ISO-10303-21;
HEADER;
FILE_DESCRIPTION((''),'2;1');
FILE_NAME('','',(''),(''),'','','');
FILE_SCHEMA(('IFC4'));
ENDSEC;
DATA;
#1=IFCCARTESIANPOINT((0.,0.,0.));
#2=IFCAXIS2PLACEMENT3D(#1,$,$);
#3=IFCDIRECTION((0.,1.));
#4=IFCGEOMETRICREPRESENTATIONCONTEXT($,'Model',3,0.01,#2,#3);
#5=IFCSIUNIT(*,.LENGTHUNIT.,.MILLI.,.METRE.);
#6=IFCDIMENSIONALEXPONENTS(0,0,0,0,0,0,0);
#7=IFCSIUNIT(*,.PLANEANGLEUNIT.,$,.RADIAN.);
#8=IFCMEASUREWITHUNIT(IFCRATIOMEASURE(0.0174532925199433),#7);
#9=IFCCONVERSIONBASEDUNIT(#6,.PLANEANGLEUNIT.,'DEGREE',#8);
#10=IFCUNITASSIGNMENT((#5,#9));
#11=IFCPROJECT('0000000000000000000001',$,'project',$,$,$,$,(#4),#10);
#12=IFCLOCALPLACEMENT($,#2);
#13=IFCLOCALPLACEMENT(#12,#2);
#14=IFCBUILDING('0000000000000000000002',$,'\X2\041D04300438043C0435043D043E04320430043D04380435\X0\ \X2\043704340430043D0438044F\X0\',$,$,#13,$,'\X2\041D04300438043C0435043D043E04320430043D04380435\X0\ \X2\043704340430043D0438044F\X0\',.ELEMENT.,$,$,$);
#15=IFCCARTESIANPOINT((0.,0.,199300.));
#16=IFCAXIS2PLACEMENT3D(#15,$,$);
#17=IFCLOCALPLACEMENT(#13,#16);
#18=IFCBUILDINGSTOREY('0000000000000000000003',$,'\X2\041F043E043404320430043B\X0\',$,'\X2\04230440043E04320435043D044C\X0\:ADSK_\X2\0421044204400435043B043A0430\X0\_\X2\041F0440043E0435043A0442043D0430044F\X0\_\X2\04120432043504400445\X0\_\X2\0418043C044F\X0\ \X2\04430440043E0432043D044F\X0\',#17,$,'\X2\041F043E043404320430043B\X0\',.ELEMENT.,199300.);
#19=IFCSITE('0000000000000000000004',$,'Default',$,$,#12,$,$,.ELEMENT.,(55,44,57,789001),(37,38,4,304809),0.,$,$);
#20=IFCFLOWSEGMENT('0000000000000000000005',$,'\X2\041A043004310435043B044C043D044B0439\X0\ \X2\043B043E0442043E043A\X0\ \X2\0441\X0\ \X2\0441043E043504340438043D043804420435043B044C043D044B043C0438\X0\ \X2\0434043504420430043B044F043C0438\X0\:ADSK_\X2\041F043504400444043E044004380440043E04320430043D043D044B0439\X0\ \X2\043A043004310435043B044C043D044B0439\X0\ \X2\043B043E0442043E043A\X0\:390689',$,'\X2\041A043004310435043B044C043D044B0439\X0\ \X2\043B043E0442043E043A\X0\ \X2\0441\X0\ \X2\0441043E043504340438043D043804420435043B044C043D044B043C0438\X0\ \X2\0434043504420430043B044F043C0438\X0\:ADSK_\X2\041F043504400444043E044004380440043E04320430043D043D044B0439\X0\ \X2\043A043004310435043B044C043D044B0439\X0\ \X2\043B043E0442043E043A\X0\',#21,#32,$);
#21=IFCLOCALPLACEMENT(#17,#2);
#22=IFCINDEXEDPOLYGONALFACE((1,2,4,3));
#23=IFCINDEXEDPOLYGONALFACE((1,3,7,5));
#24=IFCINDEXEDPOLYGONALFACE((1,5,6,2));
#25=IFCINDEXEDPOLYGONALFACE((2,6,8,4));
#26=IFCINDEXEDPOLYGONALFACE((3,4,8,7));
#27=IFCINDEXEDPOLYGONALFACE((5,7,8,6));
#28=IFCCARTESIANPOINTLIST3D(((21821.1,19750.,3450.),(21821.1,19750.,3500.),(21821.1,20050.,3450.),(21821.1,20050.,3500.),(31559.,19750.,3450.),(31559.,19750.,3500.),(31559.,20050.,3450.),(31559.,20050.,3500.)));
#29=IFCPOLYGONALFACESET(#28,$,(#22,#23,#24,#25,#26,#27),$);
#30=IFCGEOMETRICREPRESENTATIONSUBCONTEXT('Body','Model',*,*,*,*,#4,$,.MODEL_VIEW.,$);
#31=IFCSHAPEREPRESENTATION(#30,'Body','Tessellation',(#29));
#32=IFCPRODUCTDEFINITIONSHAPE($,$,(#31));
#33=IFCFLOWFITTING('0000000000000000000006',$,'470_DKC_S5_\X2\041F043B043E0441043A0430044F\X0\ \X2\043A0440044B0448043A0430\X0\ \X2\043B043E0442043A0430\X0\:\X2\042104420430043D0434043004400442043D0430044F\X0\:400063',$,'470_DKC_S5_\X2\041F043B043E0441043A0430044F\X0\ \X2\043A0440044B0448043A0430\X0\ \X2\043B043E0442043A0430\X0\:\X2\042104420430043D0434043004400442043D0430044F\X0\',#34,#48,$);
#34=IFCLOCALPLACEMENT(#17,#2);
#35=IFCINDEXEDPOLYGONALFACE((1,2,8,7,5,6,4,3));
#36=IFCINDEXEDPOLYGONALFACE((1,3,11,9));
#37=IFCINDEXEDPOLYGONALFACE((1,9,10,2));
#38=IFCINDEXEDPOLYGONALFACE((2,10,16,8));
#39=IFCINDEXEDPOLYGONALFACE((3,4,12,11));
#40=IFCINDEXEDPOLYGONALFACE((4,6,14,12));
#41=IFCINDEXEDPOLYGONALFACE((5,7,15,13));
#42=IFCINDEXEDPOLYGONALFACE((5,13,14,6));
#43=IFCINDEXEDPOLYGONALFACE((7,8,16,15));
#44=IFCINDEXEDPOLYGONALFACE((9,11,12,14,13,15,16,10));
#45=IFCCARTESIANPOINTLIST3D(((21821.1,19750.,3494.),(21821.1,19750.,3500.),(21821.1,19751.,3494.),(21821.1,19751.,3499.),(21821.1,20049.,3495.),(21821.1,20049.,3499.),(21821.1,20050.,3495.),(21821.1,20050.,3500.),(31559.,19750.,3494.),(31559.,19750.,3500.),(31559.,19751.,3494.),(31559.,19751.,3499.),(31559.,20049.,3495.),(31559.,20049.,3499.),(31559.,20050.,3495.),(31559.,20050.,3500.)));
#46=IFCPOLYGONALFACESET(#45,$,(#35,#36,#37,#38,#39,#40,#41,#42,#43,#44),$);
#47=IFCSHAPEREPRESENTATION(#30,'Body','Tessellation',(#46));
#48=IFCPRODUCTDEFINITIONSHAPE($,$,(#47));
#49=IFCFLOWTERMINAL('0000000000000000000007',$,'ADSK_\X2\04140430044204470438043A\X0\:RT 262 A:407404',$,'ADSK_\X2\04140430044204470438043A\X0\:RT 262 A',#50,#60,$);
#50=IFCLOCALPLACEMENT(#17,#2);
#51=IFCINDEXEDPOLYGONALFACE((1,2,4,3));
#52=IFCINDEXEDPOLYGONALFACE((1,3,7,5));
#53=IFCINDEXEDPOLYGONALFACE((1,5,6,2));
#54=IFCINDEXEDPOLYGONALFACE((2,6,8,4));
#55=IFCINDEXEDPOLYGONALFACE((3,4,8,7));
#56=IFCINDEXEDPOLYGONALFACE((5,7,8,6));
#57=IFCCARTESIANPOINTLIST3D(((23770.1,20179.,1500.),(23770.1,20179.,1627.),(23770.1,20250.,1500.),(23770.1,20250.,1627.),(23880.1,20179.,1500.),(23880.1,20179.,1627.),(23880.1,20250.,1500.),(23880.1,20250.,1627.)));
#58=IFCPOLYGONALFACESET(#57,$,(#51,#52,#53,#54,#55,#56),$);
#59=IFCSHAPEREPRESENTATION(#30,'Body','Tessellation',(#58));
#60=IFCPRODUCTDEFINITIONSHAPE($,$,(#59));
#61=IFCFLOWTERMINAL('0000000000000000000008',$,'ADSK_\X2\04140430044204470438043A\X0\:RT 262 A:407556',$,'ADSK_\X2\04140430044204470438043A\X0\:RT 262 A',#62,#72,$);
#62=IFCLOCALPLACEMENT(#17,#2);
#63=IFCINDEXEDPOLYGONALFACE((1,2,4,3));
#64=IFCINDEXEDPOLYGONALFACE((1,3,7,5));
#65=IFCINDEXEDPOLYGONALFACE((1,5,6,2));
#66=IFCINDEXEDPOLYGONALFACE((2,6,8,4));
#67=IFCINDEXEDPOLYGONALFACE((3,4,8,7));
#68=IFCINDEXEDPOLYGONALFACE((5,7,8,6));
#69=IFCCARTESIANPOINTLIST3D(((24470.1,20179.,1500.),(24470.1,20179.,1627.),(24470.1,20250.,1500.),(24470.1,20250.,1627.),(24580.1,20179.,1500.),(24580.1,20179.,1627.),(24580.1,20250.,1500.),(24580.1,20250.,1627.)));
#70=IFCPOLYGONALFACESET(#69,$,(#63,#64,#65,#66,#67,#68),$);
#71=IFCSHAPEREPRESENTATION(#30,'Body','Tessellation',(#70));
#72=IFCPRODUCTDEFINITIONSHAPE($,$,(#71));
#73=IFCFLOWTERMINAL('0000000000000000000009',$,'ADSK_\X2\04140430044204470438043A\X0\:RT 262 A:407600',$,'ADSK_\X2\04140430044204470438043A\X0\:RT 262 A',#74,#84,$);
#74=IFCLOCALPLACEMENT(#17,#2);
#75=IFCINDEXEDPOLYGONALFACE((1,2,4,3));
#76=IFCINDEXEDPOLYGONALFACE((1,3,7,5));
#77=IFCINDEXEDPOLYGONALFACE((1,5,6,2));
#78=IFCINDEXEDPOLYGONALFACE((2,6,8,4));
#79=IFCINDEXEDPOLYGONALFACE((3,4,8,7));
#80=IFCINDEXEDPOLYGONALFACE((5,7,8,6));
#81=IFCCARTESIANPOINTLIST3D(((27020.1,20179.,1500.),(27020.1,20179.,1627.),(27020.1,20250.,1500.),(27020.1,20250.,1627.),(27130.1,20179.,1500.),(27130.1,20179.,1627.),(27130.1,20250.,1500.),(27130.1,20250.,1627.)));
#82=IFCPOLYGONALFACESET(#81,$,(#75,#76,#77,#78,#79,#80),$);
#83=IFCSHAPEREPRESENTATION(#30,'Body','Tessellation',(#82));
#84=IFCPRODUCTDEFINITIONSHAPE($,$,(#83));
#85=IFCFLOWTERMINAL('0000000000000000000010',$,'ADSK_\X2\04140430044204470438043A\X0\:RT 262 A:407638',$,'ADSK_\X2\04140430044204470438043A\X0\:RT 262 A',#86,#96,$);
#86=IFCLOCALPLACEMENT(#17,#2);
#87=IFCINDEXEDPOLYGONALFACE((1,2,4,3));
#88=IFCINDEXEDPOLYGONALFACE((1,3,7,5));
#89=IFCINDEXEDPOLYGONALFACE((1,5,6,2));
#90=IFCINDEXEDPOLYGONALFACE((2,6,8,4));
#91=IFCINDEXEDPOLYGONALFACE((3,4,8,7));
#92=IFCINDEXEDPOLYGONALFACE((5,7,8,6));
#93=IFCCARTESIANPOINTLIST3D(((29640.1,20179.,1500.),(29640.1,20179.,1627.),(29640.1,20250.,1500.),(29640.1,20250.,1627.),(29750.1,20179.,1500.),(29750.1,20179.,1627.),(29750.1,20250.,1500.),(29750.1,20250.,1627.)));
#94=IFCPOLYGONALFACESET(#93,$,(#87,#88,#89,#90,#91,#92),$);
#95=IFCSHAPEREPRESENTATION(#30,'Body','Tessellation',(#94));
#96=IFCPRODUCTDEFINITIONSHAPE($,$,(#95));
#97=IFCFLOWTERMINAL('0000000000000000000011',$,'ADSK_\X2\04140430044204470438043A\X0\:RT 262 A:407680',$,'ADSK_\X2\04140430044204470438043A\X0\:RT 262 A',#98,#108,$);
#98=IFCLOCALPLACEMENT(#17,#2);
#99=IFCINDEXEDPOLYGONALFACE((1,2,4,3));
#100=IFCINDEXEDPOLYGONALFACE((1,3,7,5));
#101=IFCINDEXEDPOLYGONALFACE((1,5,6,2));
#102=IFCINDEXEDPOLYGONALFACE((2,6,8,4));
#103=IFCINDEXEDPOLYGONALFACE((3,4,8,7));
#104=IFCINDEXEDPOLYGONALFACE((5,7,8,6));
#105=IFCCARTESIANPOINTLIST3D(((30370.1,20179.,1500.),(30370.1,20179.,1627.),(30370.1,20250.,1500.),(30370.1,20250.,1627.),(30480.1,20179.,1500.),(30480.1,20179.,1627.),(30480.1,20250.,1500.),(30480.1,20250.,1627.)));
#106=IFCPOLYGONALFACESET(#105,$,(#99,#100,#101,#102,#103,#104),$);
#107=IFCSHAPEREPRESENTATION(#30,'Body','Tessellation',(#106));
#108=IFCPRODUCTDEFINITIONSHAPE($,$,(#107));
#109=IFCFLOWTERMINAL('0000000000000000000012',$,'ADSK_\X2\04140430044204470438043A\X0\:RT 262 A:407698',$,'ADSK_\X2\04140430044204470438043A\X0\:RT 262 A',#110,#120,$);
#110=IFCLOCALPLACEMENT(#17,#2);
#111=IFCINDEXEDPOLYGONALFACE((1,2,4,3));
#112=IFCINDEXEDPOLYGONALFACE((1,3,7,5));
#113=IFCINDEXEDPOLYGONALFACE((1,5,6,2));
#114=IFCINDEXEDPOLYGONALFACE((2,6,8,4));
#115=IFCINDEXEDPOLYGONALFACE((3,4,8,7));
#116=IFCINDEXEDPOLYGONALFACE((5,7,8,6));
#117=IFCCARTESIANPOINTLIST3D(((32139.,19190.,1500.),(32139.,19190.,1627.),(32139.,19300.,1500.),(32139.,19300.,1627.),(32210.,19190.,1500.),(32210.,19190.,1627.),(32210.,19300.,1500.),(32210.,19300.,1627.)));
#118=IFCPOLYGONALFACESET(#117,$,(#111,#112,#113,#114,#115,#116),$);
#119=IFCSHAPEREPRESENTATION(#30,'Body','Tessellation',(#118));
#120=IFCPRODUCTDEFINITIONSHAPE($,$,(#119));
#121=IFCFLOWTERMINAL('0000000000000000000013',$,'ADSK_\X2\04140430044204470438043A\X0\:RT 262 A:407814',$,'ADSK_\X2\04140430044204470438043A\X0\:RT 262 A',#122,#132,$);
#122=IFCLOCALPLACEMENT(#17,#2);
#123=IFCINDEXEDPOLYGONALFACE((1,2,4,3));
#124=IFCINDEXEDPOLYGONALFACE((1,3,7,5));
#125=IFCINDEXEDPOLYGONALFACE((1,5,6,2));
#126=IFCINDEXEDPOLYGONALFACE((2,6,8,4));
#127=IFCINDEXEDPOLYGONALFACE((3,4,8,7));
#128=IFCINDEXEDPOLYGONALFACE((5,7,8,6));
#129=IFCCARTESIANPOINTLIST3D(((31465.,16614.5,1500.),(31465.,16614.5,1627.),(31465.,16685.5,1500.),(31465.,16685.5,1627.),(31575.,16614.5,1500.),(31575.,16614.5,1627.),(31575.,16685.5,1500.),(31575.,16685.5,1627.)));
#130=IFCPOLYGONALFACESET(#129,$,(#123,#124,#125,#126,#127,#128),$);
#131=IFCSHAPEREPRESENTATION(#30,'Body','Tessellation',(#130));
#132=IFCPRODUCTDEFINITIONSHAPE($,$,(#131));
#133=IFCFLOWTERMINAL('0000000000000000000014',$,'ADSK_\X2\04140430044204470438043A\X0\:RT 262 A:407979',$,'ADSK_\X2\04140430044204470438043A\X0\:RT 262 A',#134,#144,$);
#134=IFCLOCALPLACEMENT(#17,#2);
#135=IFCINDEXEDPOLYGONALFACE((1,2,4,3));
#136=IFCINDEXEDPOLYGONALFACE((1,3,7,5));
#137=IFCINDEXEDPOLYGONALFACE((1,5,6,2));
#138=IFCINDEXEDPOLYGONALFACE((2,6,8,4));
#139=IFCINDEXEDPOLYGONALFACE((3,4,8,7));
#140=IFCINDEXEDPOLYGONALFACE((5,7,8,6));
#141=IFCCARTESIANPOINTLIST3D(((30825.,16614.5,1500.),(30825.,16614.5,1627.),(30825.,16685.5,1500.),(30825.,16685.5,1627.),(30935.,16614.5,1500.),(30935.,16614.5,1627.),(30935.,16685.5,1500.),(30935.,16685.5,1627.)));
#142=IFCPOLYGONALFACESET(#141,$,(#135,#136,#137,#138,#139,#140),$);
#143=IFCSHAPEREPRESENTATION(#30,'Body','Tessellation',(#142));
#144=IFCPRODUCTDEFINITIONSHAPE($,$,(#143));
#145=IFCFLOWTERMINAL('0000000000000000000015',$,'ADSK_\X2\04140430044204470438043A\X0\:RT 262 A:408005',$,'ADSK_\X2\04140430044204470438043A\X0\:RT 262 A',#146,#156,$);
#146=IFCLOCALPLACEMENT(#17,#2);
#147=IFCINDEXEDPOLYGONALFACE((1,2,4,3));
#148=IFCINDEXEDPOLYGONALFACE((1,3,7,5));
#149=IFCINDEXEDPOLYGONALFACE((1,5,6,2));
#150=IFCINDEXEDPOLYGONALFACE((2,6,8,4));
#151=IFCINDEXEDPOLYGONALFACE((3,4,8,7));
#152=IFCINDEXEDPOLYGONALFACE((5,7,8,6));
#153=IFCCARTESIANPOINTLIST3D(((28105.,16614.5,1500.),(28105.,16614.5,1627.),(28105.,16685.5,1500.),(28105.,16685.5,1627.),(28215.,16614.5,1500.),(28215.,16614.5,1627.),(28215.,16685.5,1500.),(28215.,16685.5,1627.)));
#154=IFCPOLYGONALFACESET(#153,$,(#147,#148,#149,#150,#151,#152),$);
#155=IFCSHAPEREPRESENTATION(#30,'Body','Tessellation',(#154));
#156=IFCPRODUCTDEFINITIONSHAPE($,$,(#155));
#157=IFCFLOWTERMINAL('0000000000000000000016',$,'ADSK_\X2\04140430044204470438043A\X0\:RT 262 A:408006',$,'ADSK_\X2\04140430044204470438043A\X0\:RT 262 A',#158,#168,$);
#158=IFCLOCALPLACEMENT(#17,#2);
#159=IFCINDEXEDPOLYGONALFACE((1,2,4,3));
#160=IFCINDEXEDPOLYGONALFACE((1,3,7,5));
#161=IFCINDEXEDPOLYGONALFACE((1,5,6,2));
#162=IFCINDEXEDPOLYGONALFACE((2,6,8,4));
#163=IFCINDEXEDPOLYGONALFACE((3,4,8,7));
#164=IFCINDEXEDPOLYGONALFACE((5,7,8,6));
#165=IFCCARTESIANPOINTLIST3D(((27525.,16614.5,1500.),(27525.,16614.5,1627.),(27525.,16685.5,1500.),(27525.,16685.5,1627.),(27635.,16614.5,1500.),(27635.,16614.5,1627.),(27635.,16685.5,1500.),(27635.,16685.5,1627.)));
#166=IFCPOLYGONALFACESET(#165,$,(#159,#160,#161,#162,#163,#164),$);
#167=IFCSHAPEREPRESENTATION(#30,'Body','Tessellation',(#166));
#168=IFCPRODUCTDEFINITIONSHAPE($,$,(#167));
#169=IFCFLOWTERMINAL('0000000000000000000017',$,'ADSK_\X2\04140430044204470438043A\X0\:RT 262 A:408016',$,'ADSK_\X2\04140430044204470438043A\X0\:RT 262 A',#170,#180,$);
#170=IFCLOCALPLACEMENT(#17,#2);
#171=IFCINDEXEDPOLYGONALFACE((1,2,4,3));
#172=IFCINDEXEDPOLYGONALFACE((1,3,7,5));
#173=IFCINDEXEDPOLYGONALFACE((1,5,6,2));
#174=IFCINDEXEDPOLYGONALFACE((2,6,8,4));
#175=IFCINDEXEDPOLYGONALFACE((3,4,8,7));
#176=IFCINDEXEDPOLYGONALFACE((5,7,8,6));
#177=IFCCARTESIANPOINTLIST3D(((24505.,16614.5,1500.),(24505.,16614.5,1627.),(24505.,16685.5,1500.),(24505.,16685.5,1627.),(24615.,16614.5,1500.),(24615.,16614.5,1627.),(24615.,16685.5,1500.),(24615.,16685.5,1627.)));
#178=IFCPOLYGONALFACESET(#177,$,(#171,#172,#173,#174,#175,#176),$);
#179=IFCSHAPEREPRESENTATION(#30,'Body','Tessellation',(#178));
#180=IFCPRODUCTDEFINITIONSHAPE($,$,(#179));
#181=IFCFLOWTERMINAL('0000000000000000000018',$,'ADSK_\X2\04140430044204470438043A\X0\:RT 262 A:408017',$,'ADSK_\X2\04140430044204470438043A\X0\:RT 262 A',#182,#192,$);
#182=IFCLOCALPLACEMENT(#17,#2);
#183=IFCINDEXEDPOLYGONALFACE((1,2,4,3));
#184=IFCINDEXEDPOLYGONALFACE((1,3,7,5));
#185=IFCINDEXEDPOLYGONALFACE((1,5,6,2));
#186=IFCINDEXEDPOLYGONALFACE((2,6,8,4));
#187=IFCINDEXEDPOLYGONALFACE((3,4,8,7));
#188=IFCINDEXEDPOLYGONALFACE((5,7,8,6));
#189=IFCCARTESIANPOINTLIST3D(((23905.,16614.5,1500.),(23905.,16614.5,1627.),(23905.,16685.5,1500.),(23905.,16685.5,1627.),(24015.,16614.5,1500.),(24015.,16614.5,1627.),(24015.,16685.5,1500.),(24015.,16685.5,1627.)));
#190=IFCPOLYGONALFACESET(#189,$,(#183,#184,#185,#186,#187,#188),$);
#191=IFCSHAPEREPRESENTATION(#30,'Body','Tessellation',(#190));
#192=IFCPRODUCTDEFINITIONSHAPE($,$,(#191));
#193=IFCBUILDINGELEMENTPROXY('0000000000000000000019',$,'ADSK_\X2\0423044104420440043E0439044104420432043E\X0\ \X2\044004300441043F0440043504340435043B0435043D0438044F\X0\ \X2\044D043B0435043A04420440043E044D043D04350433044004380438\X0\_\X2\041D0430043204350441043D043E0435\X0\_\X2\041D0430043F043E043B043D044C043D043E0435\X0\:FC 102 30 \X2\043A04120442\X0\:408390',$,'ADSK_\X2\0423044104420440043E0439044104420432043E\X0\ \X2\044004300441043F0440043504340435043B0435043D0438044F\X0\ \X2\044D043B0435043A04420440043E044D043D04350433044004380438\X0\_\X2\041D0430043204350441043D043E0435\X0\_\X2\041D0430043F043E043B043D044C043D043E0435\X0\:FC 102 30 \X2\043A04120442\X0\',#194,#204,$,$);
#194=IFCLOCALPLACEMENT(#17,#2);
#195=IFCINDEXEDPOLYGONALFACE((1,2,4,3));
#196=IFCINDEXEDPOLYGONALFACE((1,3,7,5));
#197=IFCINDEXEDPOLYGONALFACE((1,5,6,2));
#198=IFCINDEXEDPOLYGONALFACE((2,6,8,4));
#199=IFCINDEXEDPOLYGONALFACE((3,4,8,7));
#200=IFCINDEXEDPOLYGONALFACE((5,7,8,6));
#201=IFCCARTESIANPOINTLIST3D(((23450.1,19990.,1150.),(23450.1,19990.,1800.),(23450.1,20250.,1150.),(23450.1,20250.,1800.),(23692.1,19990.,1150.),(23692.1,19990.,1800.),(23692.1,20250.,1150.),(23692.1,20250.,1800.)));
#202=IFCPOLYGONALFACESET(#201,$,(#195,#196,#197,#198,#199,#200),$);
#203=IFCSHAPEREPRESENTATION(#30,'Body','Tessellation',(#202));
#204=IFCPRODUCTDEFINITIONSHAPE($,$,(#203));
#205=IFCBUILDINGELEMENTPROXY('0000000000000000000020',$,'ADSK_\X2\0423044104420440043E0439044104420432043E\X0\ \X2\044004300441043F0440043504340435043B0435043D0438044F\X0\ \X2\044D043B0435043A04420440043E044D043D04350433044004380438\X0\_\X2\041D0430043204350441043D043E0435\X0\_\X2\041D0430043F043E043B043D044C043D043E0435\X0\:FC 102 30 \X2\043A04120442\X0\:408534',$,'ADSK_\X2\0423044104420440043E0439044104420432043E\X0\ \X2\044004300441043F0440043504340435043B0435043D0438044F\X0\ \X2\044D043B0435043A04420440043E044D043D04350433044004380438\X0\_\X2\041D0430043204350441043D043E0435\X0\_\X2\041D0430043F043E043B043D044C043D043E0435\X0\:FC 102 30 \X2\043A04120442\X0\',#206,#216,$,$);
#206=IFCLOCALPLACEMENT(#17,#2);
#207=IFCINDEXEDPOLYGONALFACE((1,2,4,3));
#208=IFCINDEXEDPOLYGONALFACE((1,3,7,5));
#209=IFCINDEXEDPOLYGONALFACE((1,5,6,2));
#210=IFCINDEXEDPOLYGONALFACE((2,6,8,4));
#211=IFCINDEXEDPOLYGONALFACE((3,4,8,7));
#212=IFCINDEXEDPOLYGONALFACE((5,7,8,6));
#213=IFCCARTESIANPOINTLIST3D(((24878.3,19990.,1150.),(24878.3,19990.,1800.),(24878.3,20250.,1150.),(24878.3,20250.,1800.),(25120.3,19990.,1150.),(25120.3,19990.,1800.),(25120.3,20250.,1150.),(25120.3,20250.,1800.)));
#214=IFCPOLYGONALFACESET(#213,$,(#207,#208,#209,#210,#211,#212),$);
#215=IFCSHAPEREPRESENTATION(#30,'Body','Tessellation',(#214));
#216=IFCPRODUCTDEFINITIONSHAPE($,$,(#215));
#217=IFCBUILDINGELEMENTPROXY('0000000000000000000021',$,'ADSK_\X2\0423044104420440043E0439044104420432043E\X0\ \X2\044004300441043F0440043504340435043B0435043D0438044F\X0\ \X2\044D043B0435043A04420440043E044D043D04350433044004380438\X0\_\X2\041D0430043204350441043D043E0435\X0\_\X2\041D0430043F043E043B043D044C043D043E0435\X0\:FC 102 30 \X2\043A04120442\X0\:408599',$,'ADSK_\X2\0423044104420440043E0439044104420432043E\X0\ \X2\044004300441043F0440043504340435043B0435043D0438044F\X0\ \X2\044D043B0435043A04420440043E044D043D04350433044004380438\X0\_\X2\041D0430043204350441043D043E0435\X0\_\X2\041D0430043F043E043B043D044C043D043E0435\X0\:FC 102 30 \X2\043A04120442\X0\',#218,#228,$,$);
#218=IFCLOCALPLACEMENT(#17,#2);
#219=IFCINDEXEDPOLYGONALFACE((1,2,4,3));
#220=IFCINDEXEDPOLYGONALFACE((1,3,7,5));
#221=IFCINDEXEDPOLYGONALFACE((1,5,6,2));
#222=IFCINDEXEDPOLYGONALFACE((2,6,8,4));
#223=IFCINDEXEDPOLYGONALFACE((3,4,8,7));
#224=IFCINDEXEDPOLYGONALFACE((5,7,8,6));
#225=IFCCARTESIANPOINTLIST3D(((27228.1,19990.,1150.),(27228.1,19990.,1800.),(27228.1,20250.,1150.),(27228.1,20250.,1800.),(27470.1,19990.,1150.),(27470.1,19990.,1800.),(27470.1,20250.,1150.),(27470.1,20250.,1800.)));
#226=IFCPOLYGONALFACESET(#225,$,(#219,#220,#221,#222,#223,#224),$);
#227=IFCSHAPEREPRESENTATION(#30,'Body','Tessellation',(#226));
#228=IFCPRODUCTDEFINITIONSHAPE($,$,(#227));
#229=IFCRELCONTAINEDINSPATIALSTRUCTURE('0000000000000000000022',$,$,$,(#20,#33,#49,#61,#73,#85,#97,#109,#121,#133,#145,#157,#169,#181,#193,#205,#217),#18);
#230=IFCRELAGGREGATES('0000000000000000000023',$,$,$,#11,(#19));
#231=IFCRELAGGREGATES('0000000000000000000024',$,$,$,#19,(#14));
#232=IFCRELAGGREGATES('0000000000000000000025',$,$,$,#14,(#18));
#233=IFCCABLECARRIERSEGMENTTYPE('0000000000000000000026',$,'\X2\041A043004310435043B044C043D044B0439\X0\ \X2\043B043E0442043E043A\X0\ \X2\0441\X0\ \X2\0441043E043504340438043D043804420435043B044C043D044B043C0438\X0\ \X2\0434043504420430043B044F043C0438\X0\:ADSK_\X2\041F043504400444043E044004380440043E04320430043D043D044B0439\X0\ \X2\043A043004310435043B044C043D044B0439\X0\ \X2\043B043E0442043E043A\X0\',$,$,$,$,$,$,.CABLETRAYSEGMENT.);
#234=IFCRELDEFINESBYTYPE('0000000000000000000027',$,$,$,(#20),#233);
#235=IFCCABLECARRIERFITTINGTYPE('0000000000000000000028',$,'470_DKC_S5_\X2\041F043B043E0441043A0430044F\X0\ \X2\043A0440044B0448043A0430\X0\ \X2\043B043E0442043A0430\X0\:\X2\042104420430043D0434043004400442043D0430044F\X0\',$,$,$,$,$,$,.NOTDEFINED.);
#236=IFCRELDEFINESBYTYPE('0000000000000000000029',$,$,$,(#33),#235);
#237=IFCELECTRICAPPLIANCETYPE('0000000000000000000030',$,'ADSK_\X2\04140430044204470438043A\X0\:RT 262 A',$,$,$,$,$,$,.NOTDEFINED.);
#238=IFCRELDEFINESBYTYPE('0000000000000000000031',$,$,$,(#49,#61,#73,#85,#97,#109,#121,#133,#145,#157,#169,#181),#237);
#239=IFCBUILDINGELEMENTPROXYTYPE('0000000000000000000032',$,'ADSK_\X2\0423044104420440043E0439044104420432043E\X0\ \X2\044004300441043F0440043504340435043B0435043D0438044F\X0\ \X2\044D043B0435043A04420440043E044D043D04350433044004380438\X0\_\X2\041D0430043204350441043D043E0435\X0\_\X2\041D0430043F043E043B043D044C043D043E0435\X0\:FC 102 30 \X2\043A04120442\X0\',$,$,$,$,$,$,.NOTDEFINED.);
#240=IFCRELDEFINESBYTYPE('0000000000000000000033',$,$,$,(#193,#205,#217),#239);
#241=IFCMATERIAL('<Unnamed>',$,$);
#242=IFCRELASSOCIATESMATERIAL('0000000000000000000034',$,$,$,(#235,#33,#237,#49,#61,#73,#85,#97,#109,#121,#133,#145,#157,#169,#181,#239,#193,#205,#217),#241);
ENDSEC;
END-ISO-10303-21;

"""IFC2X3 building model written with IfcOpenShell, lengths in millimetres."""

from ifc_helpers import new_model, entity, si_unit, converted_unit, direction, frame, origin, origin_2d_with_axis, place, context, subcontext, project, spatial, polyline, rectangle, outline, extrude, source, transform, mapped, material, type_object, type_shapes, element, save


model = new_model("IFC2X3")

# Units and contexts
model_context = context("Model", 3, precision=0.01, world=origin(), true_north=direction((0.0, 1.0)))
body_context = subcontext(model_context, "Body", "Model", "MODEL_VIEW")
ifc_project = project(units=[si_unit("LENGTHUNIT", "METRE", prefix="MILLI"), converted_unit("PLANEANGLEUNIT", "DEGREE", entity("IfcRatioMeasure", 0.0174532925199433), si_unit("PLANEANGLEUNIT", "RADIAN"), dimensions=[0, 0, 0, 0, 0, 0, 0])], contexts=[model_context])

# Site, building, storey
site_placement = place(None, origin())
site = spatial("IfcSite", under=ifc_project, at=site_placement, Name="Default", CompositionType="ELEMENT", RefLatitude=(55, 44, 57, 789001), RefLongitude=(37, 38, 4, 304809), RefElevation=0.0)
building_placement = place(site_placement, origin())
building = spatial("IfcBuilding", under=site, at=building_placement, Name="Наименование здания", LongName="Наименование здания", CompositionType="ELEMENT")
storey_placement = place(building_placement, frame((0.0, 0.0, 199300.0)))
storey = spatial("IfcBuildingStorey", under=building, at=storey_placement, Name="Подвал", ObjectType="Уровень:ADSK_Стрелка_Проектная_Вверх_Имя уровня", LongName="Подвал", CompositionType="ELEMENT", Elevation=199300.0)

# Flow segment
cable_carrier_segment_type = type_object("IfcCableCarrierSegmentType", Name="Кабельный лоток с соединительными деталями:ADSK_Перфорированный кабельный лоток", PredefinedType="CABLETRAYSEGMENT")
flow_segment_placement = place(storey_placement, frame((21821.1, 19750.0, 3450.0)))
element("IfcFlowSegment", 1, at=flow_segment_placement, inside=storey, type_object=cable_carrier_segment_type, Name="Кабельный лоток с соединительными деталями:ADSK_Перфорированный кабельный лоток:390689", ObjectType="Кабельный лоток с соединительными деталями:ADSK_Перфорированный кабельный лоток", context=body_context, shape_type="SweptSolid", body=[
    extrude(rectangle(XDim=9737.9, YDim=300.0, at=origin_2d_with_axis()), frame((4868.9, 150.0, 0.0), z_axis=(0.0, 0.0, 1.0), x_axis=(-1.0, 0.0, 0.0)), (0.0, 0.0, 1.0), 50.0),
])

# Flow fitting
ifc_material = material(Name="<Unnamed>")
cable_carrier_fitting_type_1 = type_object("IfcCableCarrierFittingType", Name="470_DKC_S5_Плоская крышка лотка:Стандартная", PredefinedType="NOTDEFINED", material=ifc_material)
shared_shape_1 = source(origin(), body_context, "Body", "SweptSolid", [
    extrude(outline(polyline([(-150.0, -2.0), (-149.0, -2.0), (-149.0, 2.0), (149.0, 2.0), (149.0, -3.0), (150.0, -3.0), (150.0, 3.0), (-150.0, 3.0), (-150.0, -2.0)])), frame((0.0, 150.0, 3.0), z_axis=(1.0, 0.0, 0.0), x_axis=(0.0, 1.0, 0.0)), (0.0, 0.0, 1.0), 9737.9),
])
type_shapes(cable_carrier_fitting_type_1, [shared_shape_1])
flow_fitting_placement = place(storey_placement, frame((31559.0, 20050.0, 3494.0), z_axis=(0.0, 0.0, 1.0), x_axis=(-1.0, 0.0, 0.0)))
element("IfcFlowFitting", 2, at=flow_fitting_placement, inside=storey, type_object=cable_carrier_fitting_type_1, material=ifc_material, Name="470_DKC_S5_Плоская крышка лотка:Стандартная:400063", ObjectType="470_DKC_S5_Плоская крышка лотка:Стандартная", context=body_context, shape_type="MappedRepresentation", body=[
    mapped(shared_shape_1, transform((0.0, 0.0, 0.0), scale=1.0)),
])

# Flow terminals
electric_appliance_type = type_object("IfcElectricApplianceType", Name="ADSK_Датчик:RT 262 A", PredefinedType="NOTDEFINED", material=ifc_material)
shared_shape_2 = source(origin(), body_context, "Body", "SweptSolid", [
    extrude(rectangle(XDim=71.0, YDim=110.0, at=origin_2d_with_axis()), frame((0.0, 0.0, 0.0), z_axis=(0.0, 0.0, 1.0), x_axis=(-1.0, 0.0, 0.0)), (0.0, 0.0, 1.0), 127.0),
])
type_shapes(electric_appliance_type, [shared_shape_2])
for number, where, z_axis, x_axis, name in (
    (3, (23825.1, 20214.5, 1500.0), (0.0, 0.0, 1.0), (0.0, -1.0, 0.0), "ADSK_Датчик:RT 262 A:407404"),
    (4, (24525.1, 20214.5, 1500.0), (0.0, 0.0, 1.0), (0.0, -1.0, 0.0), "ADSK_Датчик:RT 262 A:407556"),
    (5, (27075.1, 20214.5, 1500.0), (0.0, 0.0, 1.0), (0.0, -1.0, 0.0), "ADSK_Датчик:RT 262 A:407600"),
    (6, (29695.1, 20214.5, 1500.0), (0.0, 0.0, 1.0), (0.0, -1.0, 0.0), "ADSK_Датчик:RT 262 A:407638"),
    (7, (30425.1, 20214.5, 1500.0), (0.0, 0.0, 1.0), (0.0, -1.0, 0.0), "ADSK_Датчик:RT 262 A:407680"),
    (8, (32174.5, 19245.0, 1500.0), (0.0, 0.0, 1.0), (-1.0, 0.0, 0.0), "ADSK_Датчик:RT 262 A:407698"),
    (9, (31520.0, 16650.0, 1500.0), (0.0, 0.0, 1.0), (0.0, 1.0, 0.0), "ADSK_Датчик:RT 262 A:407814"),
    (10, (30880.0, 16650.0, 1500.0), (0.0, 0.0, 1.0), (0.0, 1.0, 0.0), "ADSK_Датчик:RT 262 A:407979"),
    (11, (28160.0, 16650.0, 1500.0), (0.0, 0.0, 1.0), (0.0, 1.0, 0.0), "ADSK_Датчик:RT 262 A:408005"),
    (12, (27580.0, 16650.0, 1500.0), (0.0, 0.0, 1.0), (0.0, 1.0, 0.0), "ADSK_Датчик:RT 262 A:408006"),
    (13, (24560.0, 16650.0, 1500.0), (0.0, 0.0, 1.0), (0.0, 1.0, 0.0), "ADSK_Датчик:RT 262 A:408016"),
    (14, (23960.0, 16650.0, 1500.0), (0.0, 0.0, 1.0), (0.0, 1.0, 0.0), "ADSK_Датчик:RT 262 A:408017"),
):
    element("IfcFlowTerminal", number, at=place(storey_placement, frame(where, z_axis=z_axis, x_axis=x_axis)), inside=storey, type_object=electric_appliance_type, material=ifc_material, Name=name, ObjectType="ADSK_Датчик:RT 262 A", context=body_context, shape_type="MappedRepresentation", body=[
        mapped(shared_shape_2, transform((0.0, 0.0, 0.0), scale=1.0)),
    ])

# Building element proxies
building_element_proxy_type = type_object("IfcBuildingElementProxyType", Name="ADSK_Устройство распределения электроэнегрии_Навесное_Наполньное:FC 102 30 кВт", PredefinedType="NOTDEFINED", material=ifc_material)
shared_shape_3 = source(origin(), body_context, "Body", "SweptSolid", [
    extrude(rectangle(XDim=242.0, YDim=260.0, at=origin_2d_with_axis()), frame((0.0, 130.0, -650.0), z_axis=(0.0, 0.0, 1.0), x_axis=(-1.0, 0.0, 0.0)), (0.0, 0.0, 1.0), 650.0),
])
type_shapes(building_element_proxy_type, [shared_shape_3])
for number, where, z_axis, x_axis, name in (
    (15, (23571.1, 20250.0, 1800.0), (0.0, 0.0, 1.0), (-1.0, 0.0, 0.0), "ADSK_Устройство распределения электроэнегрии_Навесное_Наполньное:FC 102 30 кВт:408390"),
    (16, (24999.3, 20250.0, 1800.0), (0.0, 0.0, 1.0), (-1.0, 0.0, 0.0), "ADSK_Устройство распределения электроэнегрии_Навесное_Наполньное:FC 102 30 кВт:408534"),
    (17, (27349.1, 20250.0, 1800.0), (0.0, 0.0, 1.0), (-1.0, 0.0, 0.0), "ADSK_Устройство распределения электроэнегрии_Навесное_Наполньное:FC 102 30 кВт:408599"),
):
    element("IfcBuildingElementProxy", number, at=place(storey_placement, frame(where, z_axis=z_axis, x_axis=x_axis)), inside=storey, type_object=building_element_proxy_type, material=ifc_material, Name=name, ObjectType="ADSK_Устройство распределения электроэнегрии_Навесное_Наполньное:FC 102 30 кВт", context=body_context, shape_type="MappedRepresentation", body=[
        mapped(shared_shape_3, transform((0.0, 0.0, 0.0), scale=1.0)),
    ])

save(model, "model.ifc")
